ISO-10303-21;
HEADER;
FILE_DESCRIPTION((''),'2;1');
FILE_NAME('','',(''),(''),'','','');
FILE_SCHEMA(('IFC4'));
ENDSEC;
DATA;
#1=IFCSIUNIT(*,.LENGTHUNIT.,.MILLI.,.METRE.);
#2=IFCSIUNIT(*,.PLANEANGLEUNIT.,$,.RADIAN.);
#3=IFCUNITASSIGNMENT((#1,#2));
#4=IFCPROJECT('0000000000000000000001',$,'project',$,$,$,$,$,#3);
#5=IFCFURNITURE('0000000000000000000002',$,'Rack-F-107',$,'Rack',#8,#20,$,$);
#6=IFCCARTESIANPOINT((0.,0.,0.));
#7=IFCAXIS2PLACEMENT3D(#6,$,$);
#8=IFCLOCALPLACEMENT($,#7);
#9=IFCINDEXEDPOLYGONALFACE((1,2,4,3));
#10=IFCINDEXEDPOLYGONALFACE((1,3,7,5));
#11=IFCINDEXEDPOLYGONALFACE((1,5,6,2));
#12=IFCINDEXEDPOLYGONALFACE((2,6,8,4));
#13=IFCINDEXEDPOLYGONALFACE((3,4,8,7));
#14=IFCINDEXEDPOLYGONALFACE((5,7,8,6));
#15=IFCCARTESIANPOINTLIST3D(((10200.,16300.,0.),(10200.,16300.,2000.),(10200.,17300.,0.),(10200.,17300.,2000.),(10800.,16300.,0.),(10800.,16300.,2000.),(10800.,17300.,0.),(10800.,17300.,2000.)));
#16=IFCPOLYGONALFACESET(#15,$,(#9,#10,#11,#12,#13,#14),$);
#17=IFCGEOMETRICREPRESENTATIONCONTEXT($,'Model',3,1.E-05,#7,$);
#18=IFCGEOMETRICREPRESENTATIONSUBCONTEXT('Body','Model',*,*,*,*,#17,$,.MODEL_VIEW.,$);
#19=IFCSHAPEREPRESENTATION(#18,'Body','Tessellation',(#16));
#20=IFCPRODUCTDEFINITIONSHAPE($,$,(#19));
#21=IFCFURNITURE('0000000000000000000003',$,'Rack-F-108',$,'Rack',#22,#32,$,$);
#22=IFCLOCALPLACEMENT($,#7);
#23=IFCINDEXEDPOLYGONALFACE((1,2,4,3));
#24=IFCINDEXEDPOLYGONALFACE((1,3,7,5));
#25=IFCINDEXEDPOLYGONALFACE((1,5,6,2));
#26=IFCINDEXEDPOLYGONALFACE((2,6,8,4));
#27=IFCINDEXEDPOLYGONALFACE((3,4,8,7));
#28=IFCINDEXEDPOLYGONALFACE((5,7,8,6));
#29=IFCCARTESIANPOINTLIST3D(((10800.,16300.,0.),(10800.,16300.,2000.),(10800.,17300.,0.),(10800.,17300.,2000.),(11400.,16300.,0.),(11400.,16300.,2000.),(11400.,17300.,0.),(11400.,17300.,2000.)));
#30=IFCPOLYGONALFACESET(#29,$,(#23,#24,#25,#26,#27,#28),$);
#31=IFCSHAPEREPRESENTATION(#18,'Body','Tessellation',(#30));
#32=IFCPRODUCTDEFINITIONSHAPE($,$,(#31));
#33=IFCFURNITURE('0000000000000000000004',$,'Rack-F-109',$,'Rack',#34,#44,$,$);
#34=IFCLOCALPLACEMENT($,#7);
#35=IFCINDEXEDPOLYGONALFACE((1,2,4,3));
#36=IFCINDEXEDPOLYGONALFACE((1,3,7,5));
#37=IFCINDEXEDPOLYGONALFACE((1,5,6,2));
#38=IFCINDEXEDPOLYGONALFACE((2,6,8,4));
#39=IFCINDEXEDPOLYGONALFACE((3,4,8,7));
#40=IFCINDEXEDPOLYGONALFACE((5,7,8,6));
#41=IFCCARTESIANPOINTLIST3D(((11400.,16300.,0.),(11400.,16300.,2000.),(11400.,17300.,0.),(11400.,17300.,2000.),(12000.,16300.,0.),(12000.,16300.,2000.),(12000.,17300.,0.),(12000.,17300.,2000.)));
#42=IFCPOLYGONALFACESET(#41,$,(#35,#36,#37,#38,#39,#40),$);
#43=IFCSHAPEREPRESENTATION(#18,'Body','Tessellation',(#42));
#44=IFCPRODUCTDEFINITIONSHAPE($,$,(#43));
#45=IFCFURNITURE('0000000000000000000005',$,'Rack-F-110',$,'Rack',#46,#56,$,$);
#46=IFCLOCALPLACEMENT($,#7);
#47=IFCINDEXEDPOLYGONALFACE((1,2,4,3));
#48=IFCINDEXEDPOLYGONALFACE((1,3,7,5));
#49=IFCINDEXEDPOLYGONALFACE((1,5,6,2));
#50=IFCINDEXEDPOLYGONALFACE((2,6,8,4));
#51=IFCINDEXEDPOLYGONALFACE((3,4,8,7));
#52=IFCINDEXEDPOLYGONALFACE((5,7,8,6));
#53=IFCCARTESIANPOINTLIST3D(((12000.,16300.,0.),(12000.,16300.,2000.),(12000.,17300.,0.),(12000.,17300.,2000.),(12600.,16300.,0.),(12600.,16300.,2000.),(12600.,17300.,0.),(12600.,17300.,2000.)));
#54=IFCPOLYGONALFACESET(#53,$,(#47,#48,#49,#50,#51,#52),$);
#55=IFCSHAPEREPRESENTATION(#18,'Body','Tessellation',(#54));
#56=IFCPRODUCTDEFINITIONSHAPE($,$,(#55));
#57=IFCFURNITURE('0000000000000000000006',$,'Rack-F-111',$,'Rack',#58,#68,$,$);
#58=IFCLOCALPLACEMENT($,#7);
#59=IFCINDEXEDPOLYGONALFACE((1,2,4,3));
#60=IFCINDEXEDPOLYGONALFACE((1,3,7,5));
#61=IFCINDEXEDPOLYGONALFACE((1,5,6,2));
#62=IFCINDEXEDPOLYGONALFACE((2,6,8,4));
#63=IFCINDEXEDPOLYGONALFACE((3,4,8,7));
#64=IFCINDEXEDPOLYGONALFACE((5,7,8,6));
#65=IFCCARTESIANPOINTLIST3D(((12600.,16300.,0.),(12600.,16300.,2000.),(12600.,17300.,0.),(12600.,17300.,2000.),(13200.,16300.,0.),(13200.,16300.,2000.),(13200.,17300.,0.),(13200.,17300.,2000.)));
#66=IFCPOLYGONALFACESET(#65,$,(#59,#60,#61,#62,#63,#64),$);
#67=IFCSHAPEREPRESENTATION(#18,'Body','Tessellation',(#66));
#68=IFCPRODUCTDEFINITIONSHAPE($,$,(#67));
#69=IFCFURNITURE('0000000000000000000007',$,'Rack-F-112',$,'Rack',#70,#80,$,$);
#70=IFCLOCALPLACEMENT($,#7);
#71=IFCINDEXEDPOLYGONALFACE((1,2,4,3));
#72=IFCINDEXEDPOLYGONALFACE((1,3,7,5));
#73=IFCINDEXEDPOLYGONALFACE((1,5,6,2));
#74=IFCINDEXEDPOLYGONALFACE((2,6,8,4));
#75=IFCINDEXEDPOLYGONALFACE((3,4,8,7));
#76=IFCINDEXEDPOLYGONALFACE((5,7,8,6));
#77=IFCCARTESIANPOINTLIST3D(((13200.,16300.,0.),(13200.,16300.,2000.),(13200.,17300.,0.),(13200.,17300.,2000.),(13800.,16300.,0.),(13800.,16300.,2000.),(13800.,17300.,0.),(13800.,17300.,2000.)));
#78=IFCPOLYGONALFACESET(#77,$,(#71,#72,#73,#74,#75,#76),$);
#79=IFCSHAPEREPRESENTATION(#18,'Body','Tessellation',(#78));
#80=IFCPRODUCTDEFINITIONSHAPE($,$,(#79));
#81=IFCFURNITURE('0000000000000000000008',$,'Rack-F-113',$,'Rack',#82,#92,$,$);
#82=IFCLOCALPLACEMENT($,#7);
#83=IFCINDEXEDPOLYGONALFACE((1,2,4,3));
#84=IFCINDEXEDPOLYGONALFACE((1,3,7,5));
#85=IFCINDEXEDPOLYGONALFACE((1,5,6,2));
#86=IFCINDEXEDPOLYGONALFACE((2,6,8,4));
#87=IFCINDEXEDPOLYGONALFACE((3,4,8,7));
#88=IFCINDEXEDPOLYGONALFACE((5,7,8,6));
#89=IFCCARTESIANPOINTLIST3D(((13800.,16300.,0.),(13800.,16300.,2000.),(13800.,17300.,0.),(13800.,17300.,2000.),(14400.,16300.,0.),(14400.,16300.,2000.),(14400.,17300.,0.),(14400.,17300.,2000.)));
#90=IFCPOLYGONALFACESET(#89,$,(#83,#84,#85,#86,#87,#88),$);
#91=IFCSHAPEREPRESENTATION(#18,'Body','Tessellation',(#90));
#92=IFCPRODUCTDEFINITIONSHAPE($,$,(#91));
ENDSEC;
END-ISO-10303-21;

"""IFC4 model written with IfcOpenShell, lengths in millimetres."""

from ifc_helpers import new_model, si_unit, frame, origin, place, context, subcontext, project, rectangle, extrude, element, save


model = new_model("IFC4")

# Units and contexts
model_context = context("Model", 3, precision=1e-05, world=origin())
body_context = subcontext(model_context, "Body", "Model", "MODEL_VIEW")
ifc_project = project(units=[si_unit("LENGTHUNIT", "METRE", prefix="MILLI"), si_unit("PLANEANGLEUNIT", "RADIAN")])

# Furniture
for number, where, name in (
    (1, (10500.0, 16800.0, 0.0), "Rack-F-107"),
    (2, (11100.0, 16800.0, 0.0), "Rack-F-108"),
    (3, (11700.0, 16800.0, 0.0), "Rack-F-109"),
    (4, (12300.0, 16800.0, 0.0), "Rack-F-110"),
    (5, (12900.0, 16800.0, 0.0), "Rack-F-111"),
    (6, (13500.0, 16800.0, 0.0), "Rack-F-112"),
    (7, (14100.0, 16800.0, 0.0), "Rack-F-113"),
):
    element("IfcFurniture", number, at=place(None, frame(where)), Name=name, ObjectType="Rack", context=body_context, shape_type="SweptSolid", body=[
        extrude(rectangle(XDim=600.0, YDim=1000.0), None, (0.0, 0.0, 1.0), 2000.0),
    ])

save(model, "model.ifc")
